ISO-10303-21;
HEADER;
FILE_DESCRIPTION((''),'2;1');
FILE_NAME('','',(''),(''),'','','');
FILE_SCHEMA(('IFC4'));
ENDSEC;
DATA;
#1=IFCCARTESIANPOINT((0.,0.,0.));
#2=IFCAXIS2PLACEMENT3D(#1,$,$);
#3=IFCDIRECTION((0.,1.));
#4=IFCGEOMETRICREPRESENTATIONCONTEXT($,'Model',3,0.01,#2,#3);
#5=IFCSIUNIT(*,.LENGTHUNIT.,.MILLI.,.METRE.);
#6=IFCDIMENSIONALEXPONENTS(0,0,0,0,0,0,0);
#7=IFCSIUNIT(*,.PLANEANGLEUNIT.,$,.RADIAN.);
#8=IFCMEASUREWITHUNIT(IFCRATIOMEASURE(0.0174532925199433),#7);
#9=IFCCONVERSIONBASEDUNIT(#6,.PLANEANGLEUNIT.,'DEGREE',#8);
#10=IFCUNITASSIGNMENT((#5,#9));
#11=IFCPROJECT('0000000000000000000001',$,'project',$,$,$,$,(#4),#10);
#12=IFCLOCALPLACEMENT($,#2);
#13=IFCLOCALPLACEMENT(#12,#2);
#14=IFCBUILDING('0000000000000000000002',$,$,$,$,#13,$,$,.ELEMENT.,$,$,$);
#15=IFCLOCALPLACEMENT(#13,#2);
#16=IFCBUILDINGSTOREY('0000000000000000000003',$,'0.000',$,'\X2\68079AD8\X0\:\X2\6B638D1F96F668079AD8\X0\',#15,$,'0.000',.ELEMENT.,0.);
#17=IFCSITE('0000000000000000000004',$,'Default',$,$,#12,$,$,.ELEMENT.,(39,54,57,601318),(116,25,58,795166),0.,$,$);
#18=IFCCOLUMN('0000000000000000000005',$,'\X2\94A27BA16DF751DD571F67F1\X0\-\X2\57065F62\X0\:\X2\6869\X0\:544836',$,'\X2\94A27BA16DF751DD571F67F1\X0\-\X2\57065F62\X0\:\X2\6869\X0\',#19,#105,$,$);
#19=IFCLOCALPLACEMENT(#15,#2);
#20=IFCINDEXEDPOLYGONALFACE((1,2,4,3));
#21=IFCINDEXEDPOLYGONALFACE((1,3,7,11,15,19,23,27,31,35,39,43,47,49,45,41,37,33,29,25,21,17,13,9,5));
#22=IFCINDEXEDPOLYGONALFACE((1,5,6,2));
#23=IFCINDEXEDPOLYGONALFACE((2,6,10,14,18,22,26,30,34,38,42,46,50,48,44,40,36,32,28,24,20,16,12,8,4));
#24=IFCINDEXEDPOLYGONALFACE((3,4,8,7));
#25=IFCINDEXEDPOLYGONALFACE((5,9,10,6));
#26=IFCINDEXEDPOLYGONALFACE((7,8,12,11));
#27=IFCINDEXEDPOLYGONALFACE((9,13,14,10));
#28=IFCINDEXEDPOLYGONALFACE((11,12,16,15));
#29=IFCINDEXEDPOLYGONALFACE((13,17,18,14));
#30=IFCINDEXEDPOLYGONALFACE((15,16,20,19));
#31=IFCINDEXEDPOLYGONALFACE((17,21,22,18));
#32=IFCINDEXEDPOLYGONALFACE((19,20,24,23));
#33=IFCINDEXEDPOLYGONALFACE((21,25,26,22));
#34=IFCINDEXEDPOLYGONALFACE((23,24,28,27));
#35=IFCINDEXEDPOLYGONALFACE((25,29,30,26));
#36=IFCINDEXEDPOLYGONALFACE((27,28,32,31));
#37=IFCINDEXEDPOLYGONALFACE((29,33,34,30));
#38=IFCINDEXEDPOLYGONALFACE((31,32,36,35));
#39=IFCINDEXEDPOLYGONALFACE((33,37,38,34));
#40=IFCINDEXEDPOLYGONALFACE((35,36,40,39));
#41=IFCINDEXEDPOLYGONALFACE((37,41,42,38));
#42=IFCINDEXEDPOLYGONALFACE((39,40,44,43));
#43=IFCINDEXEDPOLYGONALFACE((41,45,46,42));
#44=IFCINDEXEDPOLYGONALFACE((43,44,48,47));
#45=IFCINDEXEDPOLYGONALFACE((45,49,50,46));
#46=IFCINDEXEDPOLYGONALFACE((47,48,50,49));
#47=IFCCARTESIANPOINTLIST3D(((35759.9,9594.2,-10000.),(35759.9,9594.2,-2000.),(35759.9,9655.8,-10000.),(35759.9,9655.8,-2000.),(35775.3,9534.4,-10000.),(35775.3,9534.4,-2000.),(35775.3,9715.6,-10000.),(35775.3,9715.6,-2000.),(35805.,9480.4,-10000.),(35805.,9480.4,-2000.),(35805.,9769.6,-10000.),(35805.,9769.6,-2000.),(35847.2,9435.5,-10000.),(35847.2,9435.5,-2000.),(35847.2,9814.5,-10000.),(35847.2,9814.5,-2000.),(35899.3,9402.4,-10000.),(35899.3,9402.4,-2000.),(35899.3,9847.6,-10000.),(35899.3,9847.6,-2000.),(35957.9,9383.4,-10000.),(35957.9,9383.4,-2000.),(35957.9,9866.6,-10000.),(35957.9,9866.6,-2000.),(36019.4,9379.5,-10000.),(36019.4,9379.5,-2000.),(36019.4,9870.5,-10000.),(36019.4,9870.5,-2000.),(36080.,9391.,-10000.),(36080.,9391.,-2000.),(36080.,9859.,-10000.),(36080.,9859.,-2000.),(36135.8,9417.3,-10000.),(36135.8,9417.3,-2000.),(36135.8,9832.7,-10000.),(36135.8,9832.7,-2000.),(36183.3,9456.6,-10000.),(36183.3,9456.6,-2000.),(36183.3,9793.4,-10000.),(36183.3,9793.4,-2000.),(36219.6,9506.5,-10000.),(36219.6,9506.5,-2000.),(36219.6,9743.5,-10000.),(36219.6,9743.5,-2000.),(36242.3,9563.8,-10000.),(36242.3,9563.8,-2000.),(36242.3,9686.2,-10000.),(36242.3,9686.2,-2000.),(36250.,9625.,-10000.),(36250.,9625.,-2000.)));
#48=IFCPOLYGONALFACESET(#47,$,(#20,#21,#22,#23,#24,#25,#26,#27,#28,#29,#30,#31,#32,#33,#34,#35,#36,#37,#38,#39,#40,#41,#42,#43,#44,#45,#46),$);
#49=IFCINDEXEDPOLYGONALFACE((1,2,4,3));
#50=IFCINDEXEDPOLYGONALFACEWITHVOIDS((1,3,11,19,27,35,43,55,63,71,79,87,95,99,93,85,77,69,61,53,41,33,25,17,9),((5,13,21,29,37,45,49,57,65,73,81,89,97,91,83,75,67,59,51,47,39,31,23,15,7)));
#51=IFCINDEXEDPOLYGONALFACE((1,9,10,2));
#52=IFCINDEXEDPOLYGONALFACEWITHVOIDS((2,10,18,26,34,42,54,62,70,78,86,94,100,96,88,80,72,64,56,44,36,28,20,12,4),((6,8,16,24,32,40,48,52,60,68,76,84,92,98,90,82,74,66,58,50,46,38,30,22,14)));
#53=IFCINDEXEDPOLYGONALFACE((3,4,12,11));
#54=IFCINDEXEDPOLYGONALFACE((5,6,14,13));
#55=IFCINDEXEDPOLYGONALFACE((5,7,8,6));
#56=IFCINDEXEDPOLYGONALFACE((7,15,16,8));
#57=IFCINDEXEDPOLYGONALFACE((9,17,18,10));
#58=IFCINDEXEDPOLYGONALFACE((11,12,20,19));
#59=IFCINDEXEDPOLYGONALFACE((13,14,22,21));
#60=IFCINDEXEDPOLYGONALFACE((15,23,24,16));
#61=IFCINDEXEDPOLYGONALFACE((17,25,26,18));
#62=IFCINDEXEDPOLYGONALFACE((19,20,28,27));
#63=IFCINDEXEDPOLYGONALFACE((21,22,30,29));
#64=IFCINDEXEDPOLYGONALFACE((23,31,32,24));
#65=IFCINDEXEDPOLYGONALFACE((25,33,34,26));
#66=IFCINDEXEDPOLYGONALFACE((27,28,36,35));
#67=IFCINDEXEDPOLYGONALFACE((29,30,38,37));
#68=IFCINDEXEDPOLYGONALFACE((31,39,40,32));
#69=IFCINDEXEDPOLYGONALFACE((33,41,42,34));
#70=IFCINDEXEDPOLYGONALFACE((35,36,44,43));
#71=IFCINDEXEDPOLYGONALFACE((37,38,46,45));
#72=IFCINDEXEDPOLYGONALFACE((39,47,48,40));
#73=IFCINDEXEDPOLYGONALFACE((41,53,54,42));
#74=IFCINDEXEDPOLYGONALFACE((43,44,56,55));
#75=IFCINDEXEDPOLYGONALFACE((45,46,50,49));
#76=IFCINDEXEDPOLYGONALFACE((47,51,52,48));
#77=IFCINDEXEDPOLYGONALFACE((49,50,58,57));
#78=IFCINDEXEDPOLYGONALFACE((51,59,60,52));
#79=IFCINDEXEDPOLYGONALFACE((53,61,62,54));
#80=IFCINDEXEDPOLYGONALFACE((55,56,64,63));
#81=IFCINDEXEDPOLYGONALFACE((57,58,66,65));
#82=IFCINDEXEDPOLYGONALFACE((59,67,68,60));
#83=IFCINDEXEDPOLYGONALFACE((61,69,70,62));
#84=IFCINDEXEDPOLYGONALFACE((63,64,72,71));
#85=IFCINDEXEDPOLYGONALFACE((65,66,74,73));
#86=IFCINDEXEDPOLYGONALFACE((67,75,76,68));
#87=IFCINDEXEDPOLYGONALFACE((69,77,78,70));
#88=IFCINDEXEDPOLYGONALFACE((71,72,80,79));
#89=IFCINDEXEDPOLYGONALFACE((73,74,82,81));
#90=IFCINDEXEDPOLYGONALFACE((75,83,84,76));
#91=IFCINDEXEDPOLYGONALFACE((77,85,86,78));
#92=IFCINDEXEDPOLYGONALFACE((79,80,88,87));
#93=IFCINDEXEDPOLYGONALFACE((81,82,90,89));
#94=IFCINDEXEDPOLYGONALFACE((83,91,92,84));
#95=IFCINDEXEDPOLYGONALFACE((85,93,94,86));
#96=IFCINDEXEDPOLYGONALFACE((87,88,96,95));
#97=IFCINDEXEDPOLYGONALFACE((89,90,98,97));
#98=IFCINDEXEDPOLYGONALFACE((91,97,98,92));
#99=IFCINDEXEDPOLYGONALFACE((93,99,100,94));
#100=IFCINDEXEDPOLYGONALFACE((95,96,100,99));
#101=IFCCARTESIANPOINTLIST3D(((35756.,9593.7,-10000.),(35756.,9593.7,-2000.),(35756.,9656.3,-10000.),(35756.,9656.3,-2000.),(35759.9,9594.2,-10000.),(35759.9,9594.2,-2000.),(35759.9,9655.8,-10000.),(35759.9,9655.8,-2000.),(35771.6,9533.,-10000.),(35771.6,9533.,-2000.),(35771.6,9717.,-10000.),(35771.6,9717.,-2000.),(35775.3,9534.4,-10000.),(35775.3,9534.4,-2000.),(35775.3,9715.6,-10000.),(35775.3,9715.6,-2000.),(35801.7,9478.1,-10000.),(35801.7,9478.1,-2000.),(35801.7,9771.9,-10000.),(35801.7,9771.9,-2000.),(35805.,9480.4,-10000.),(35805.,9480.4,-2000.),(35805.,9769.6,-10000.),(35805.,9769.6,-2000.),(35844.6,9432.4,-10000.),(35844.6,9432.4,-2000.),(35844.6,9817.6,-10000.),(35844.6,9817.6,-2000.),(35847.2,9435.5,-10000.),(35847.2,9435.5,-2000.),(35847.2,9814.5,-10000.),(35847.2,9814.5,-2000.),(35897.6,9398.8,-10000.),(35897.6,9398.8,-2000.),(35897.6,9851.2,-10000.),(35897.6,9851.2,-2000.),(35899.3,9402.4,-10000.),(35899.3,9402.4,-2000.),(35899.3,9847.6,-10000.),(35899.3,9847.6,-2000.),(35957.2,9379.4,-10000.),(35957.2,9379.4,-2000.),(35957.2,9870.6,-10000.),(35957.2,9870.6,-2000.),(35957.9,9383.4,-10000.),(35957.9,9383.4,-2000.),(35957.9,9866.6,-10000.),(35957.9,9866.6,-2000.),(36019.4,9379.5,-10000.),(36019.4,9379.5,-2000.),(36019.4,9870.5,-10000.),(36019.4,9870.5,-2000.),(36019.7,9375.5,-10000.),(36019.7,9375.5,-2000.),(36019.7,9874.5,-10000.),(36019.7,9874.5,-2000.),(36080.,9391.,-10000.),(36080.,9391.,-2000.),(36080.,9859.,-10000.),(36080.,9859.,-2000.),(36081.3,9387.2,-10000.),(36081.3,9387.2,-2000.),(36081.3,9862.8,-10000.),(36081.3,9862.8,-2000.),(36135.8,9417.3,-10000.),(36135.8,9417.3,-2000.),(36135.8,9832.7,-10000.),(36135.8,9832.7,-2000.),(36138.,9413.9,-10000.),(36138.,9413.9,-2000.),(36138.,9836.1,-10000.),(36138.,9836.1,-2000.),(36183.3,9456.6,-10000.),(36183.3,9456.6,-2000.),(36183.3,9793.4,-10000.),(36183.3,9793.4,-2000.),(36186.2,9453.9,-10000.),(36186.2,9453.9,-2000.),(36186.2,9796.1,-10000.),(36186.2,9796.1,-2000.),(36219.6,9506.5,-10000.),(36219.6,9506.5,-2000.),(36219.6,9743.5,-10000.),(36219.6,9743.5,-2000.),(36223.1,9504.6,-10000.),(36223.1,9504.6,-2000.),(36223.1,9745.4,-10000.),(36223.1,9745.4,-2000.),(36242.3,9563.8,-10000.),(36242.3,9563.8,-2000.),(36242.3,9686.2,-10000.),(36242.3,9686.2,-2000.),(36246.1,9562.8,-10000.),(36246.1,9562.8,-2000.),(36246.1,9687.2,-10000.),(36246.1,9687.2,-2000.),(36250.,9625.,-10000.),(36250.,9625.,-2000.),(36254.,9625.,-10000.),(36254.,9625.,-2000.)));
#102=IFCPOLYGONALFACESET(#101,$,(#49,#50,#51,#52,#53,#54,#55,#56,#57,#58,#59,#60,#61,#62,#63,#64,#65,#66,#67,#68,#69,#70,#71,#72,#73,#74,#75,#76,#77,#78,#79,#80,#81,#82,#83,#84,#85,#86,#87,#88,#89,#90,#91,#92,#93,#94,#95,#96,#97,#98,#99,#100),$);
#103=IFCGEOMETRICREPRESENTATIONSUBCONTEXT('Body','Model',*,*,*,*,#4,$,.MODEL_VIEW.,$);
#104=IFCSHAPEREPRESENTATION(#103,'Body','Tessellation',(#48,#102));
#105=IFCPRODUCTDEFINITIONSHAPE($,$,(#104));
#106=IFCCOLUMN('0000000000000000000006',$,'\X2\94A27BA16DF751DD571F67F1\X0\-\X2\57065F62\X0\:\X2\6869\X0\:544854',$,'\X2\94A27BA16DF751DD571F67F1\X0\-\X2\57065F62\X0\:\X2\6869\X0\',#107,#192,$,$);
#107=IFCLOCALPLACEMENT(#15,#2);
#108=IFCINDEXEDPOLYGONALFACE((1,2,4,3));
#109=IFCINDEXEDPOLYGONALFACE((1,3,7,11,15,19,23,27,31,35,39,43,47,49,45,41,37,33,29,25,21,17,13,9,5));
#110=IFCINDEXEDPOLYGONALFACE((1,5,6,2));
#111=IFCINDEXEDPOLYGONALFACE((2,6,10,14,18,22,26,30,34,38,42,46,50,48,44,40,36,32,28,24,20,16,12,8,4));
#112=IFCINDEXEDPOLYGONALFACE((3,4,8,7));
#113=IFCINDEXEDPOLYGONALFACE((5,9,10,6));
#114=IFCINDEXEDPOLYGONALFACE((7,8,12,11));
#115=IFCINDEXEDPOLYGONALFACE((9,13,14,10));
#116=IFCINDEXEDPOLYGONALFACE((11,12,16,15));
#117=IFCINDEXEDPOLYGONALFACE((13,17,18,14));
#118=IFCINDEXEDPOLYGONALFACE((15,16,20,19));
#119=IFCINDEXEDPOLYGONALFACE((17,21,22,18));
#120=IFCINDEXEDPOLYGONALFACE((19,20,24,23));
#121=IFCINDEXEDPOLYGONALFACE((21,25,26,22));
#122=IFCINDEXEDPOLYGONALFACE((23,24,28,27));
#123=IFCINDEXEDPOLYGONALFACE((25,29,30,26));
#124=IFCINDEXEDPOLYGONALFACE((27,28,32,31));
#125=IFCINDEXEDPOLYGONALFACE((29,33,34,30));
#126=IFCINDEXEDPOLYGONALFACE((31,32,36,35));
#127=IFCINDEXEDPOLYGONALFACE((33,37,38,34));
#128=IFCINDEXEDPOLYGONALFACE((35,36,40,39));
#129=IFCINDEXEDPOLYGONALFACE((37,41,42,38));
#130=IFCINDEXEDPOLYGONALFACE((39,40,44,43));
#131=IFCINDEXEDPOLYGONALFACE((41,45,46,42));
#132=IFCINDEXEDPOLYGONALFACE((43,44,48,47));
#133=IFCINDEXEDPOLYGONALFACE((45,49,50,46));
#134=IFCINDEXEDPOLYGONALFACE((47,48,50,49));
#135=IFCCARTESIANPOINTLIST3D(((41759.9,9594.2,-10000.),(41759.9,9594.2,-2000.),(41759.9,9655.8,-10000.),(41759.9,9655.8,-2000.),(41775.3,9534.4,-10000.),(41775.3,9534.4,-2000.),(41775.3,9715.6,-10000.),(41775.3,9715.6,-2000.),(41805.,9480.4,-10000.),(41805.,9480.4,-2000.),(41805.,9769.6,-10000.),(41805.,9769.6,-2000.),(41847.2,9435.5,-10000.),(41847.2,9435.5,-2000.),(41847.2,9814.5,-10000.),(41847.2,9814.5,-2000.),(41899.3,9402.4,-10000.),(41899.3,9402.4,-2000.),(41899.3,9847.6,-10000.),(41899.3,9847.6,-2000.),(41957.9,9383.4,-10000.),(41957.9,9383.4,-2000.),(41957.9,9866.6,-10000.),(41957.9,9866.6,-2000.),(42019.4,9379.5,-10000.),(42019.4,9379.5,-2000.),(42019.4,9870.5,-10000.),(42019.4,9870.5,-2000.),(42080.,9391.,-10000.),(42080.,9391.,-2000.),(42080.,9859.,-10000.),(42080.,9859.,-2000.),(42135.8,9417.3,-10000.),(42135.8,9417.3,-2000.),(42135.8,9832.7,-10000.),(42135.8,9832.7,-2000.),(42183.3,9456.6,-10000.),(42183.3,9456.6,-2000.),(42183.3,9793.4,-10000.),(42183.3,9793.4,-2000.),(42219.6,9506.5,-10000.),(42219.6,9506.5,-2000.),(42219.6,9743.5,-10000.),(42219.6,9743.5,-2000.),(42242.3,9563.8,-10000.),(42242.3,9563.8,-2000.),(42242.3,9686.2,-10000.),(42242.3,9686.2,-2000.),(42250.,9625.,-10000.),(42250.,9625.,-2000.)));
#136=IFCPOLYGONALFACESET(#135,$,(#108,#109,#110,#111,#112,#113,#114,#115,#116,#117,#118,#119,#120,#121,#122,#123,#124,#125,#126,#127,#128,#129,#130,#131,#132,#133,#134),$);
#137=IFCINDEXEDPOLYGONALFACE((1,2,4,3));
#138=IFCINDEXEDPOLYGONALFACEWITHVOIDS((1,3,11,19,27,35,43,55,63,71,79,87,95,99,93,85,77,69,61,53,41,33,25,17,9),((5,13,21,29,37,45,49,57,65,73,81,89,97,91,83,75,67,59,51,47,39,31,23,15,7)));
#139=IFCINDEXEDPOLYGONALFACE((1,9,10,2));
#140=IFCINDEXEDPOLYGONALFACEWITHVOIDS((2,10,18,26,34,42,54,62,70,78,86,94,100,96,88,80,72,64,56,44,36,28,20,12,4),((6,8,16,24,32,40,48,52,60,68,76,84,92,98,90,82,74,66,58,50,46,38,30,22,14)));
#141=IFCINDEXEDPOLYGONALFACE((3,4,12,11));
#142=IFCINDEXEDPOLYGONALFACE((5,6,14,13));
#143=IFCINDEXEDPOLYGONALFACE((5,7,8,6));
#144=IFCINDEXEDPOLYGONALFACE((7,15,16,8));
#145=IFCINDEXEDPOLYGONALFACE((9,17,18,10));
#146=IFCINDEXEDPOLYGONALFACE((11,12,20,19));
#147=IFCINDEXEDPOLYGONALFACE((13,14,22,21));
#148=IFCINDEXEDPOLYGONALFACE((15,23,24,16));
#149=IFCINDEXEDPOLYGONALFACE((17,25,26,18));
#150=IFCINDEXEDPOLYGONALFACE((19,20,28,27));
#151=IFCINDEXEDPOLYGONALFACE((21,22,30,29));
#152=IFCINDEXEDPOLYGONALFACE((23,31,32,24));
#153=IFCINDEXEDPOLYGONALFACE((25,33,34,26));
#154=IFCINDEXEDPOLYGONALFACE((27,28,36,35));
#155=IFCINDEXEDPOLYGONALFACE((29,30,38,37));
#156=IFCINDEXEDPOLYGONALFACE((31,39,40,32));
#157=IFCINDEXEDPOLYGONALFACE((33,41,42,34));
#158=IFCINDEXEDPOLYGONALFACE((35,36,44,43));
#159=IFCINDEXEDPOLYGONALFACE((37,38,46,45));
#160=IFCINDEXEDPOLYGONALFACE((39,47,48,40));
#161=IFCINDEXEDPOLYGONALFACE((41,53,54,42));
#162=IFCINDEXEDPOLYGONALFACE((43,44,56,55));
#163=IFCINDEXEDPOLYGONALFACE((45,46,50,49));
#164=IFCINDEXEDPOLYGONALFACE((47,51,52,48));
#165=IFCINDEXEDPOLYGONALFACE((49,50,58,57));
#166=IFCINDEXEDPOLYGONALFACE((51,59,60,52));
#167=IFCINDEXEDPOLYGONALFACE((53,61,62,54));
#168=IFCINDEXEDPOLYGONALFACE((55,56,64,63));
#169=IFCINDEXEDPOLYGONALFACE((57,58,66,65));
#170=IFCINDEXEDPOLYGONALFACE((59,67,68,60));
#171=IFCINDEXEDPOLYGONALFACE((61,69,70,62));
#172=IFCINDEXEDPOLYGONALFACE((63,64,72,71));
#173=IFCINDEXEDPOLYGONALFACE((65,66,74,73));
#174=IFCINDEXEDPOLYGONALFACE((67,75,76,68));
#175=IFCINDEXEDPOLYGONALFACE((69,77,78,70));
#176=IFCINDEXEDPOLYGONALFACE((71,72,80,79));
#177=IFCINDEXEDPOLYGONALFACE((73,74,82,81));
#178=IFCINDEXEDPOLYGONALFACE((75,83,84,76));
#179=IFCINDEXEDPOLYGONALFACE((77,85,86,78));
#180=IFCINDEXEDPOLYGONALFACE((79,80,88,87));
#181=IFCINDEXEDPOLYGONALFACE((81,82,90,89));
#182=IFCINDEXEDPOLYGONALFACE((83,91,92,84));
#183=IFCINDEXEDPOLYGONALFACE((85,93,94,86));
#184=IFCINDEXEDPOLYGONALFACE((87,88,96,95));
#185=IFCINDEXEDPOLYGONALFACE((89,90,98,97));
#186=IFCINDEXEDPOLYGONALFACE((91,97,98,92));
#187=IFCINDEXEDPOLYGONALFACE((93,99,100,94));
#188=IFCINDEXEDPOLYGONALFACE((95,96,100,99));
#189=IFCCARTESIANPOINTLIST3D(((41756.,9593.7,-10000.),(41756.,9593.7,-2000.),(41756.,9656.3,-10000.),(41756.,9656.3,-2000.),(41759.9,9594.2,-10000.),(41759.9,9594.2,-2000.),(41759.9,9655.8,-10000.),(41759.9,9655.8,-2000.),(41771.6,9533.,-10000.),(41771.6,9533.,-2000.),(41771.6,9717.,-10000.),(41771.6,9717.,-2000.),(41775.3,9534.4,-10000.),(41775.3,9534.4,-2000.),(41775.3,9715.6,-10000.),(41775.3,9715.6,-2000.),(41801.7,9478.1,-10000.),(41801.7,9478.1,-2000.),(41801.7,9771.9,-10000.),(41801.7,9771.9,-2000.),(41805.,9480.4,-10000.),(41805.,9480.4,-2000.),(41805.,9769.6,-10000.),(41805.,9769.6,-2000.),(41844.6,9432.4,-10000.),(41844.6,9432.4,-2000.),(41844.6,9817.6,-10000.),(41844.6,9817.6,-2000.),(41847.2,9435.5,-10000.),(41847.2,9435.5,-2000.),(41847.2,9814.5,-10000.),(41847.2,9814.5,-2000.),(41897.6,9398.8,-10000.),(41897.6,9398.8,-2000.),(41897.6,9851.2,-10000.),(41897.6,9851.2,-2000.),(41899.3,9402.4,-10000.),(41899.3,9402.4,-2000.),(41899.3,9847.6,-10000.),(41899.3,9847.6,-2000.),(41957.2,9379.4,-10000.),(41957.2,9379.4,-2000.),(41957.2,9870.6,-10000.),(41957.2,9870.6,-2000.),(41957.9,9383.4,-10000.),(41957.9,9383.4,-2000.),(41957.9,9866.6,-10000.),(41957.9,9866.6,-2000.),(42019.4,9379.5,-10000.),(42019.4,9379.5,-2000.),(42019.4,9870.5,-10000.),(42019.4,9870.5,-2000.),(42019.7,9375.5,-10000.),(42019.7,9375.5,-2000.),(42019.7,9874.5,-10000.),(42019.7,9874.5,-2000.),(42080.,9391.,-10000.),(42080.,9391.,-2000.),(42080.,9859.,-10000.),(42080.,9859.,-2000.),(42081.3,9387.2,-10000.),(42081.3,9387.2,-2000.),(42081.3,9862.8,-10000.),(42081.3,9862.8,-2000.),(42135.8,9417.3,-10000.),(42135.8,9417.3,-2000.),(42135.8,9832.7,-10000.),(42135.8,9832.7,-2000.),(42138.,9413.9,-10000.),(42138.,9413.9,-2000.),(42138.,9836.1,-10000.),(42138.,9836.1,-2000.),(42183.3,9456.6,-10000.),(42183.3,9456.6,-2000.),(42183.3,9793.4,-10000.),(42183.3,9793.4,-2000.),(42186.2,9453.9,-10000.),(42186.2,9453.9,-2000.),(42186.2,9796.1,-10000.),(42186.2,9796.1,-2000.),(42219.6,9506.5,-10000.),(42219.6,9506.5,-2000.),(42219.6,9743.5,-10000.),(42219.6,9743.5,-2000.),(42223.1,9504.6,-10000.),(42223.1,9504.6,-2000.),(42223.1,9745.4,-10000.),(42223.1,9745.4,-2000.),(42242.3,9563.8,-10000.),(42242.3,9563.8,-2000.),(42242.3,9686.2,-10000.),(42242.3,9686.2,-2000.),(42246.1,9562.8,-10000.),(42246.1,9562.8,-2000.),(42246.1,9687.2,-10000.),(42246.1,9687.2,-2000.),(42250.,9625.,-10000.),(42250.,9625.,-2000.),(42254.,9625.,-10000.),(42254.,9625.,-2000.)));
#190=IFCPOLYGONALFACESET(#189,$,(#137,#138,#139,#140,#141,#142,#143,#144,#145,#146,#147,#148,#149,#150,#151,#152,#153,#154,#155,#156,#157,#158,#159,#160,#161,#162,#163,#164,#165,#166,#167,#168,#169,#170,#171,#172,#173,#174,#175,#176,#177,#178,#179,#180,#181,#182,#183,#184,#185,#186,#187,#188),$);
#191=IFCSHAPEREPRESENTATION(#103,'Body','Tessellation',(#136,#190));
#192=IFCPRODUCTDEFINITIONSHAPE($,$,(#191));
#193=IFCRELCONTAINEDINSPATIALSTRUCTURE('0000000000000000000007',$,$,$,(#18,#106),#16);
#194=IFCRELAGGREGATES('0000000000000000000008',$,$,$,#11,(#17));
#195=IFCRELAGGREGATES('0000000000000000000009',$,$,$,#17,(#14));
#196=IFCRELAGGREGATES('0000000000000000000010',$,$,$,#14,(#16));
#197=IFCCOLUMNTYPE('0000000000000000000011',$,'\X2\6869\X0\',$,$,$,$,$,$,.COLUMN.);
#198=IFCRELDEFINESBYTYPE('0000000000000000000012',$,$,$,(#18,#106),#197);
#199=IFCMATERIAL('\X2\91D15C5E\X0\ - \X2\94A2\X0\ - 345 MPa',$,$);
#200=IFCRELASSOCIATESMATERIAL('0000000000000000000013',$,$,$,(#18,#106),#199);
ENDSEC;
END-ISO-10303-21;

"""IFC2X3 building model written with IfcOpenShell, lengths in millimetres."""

from ifc_helpers import new_model, entity, si_unit, converted_unit, direction, frame, frame_2d, origin, place, context, subcontext, project, spatial, circle, hollow_circle, extrude, source, transform, mapped, material, type_object, type_shapes, element, save


model = new_model("IFC2X3")

# Units and contexts
model_context = context("Model", 3, precision=0.01, world=origin(), true_north=direction((0.0, 1.0)))
body_context = subcontext(model_context, "Body", "Model", "MODEL_VIEW")
ifc_project = project(units=[si_unit("LENGTHUNIT", "METRE", prefix="MILLI"), converted_unit("PLANEANGLEUNIT", "DEGREE", entity("IfcRatioMeasure", 0.0174532925199433), si_unit("PLANEANGLEUNIT", "RADIAN"), dimensions=[0, 0, 0, 0, 0, 0, 0])], contexts=[model_context])

# Site, building, storey
site_placement = place(None, origin())
site = spatial("IfcSite", under=ifc_project, at=site_placement, Name="Default", CompositionType="ELEMENT", RefLatitude=(39, 54, 57, 601318), RefLongitude=(116, 25, 58, 795166), RefElevation=0.0)
building_placement = place(site_placement, origin())
building = spatial("IfcBuilding", under=site, at=building_placement, CompositionType="ELEMENT")
storey_placement = place(building_placement, origin())
storey = spatial("IfcBuildingStorey", under=building, at=storey_placement, Name="0.000", ObjectType="标高:正负零标高", LongName="0.000", CompositionType="ELEMENT", Elevation=0.0)

# Columns
ifc_material_1 = material(Name="金属 - 钢 - 345 MPa")
column_type_1 = type_object("IfcColumnType", Name="桩", PredefinedType="COLUMN")
shared_shape_1 = source(origin(), body_context, "Body", "SweptSolid", [
    extrude(circle(Radius=246.0, at=frame_2d((0.0, 0.0), x_axis=(1.0, 0.0))), frame((0.0, 0.0, -10000.0)), (0.0, 0.0, 1.0), 8000.0),
    extrude(hollow_circle(Radius=250.0, WallThickness=4.0, at=frame_2d((0.0, 0.0), x_axis=(1.0, 0.0))), frame((0.0, 0.0, -10000.0)), (0.0, 0.0, 1.0), 8000.0),
])
type_shapes(column_type_1, [shared_shape_1])
for number, where, name in (
    (1, (36004.0, 9625.0, 0.0), "钢管混凝土柱-圆形:桩:544836"),
    (2, (42004.0, 9625.0, 0.0), "钢管混凝土柱-圆形:桩:544854"),
):
    element("IfcColumn", number, at=place(storey_placement, frame(where)), inside=storey, type_object=column_type_1, material=ifc_material_1, Name=name, ObjectType="钢管混凝土柱-圆形:桩", context=body_context, shape_type="MappedRepresentation", body=[
        mapped(shared_shape_1, transform((0.0, 0.0, 0.0), scale=1.0)),
    ])

save(model, "model.ifc")
